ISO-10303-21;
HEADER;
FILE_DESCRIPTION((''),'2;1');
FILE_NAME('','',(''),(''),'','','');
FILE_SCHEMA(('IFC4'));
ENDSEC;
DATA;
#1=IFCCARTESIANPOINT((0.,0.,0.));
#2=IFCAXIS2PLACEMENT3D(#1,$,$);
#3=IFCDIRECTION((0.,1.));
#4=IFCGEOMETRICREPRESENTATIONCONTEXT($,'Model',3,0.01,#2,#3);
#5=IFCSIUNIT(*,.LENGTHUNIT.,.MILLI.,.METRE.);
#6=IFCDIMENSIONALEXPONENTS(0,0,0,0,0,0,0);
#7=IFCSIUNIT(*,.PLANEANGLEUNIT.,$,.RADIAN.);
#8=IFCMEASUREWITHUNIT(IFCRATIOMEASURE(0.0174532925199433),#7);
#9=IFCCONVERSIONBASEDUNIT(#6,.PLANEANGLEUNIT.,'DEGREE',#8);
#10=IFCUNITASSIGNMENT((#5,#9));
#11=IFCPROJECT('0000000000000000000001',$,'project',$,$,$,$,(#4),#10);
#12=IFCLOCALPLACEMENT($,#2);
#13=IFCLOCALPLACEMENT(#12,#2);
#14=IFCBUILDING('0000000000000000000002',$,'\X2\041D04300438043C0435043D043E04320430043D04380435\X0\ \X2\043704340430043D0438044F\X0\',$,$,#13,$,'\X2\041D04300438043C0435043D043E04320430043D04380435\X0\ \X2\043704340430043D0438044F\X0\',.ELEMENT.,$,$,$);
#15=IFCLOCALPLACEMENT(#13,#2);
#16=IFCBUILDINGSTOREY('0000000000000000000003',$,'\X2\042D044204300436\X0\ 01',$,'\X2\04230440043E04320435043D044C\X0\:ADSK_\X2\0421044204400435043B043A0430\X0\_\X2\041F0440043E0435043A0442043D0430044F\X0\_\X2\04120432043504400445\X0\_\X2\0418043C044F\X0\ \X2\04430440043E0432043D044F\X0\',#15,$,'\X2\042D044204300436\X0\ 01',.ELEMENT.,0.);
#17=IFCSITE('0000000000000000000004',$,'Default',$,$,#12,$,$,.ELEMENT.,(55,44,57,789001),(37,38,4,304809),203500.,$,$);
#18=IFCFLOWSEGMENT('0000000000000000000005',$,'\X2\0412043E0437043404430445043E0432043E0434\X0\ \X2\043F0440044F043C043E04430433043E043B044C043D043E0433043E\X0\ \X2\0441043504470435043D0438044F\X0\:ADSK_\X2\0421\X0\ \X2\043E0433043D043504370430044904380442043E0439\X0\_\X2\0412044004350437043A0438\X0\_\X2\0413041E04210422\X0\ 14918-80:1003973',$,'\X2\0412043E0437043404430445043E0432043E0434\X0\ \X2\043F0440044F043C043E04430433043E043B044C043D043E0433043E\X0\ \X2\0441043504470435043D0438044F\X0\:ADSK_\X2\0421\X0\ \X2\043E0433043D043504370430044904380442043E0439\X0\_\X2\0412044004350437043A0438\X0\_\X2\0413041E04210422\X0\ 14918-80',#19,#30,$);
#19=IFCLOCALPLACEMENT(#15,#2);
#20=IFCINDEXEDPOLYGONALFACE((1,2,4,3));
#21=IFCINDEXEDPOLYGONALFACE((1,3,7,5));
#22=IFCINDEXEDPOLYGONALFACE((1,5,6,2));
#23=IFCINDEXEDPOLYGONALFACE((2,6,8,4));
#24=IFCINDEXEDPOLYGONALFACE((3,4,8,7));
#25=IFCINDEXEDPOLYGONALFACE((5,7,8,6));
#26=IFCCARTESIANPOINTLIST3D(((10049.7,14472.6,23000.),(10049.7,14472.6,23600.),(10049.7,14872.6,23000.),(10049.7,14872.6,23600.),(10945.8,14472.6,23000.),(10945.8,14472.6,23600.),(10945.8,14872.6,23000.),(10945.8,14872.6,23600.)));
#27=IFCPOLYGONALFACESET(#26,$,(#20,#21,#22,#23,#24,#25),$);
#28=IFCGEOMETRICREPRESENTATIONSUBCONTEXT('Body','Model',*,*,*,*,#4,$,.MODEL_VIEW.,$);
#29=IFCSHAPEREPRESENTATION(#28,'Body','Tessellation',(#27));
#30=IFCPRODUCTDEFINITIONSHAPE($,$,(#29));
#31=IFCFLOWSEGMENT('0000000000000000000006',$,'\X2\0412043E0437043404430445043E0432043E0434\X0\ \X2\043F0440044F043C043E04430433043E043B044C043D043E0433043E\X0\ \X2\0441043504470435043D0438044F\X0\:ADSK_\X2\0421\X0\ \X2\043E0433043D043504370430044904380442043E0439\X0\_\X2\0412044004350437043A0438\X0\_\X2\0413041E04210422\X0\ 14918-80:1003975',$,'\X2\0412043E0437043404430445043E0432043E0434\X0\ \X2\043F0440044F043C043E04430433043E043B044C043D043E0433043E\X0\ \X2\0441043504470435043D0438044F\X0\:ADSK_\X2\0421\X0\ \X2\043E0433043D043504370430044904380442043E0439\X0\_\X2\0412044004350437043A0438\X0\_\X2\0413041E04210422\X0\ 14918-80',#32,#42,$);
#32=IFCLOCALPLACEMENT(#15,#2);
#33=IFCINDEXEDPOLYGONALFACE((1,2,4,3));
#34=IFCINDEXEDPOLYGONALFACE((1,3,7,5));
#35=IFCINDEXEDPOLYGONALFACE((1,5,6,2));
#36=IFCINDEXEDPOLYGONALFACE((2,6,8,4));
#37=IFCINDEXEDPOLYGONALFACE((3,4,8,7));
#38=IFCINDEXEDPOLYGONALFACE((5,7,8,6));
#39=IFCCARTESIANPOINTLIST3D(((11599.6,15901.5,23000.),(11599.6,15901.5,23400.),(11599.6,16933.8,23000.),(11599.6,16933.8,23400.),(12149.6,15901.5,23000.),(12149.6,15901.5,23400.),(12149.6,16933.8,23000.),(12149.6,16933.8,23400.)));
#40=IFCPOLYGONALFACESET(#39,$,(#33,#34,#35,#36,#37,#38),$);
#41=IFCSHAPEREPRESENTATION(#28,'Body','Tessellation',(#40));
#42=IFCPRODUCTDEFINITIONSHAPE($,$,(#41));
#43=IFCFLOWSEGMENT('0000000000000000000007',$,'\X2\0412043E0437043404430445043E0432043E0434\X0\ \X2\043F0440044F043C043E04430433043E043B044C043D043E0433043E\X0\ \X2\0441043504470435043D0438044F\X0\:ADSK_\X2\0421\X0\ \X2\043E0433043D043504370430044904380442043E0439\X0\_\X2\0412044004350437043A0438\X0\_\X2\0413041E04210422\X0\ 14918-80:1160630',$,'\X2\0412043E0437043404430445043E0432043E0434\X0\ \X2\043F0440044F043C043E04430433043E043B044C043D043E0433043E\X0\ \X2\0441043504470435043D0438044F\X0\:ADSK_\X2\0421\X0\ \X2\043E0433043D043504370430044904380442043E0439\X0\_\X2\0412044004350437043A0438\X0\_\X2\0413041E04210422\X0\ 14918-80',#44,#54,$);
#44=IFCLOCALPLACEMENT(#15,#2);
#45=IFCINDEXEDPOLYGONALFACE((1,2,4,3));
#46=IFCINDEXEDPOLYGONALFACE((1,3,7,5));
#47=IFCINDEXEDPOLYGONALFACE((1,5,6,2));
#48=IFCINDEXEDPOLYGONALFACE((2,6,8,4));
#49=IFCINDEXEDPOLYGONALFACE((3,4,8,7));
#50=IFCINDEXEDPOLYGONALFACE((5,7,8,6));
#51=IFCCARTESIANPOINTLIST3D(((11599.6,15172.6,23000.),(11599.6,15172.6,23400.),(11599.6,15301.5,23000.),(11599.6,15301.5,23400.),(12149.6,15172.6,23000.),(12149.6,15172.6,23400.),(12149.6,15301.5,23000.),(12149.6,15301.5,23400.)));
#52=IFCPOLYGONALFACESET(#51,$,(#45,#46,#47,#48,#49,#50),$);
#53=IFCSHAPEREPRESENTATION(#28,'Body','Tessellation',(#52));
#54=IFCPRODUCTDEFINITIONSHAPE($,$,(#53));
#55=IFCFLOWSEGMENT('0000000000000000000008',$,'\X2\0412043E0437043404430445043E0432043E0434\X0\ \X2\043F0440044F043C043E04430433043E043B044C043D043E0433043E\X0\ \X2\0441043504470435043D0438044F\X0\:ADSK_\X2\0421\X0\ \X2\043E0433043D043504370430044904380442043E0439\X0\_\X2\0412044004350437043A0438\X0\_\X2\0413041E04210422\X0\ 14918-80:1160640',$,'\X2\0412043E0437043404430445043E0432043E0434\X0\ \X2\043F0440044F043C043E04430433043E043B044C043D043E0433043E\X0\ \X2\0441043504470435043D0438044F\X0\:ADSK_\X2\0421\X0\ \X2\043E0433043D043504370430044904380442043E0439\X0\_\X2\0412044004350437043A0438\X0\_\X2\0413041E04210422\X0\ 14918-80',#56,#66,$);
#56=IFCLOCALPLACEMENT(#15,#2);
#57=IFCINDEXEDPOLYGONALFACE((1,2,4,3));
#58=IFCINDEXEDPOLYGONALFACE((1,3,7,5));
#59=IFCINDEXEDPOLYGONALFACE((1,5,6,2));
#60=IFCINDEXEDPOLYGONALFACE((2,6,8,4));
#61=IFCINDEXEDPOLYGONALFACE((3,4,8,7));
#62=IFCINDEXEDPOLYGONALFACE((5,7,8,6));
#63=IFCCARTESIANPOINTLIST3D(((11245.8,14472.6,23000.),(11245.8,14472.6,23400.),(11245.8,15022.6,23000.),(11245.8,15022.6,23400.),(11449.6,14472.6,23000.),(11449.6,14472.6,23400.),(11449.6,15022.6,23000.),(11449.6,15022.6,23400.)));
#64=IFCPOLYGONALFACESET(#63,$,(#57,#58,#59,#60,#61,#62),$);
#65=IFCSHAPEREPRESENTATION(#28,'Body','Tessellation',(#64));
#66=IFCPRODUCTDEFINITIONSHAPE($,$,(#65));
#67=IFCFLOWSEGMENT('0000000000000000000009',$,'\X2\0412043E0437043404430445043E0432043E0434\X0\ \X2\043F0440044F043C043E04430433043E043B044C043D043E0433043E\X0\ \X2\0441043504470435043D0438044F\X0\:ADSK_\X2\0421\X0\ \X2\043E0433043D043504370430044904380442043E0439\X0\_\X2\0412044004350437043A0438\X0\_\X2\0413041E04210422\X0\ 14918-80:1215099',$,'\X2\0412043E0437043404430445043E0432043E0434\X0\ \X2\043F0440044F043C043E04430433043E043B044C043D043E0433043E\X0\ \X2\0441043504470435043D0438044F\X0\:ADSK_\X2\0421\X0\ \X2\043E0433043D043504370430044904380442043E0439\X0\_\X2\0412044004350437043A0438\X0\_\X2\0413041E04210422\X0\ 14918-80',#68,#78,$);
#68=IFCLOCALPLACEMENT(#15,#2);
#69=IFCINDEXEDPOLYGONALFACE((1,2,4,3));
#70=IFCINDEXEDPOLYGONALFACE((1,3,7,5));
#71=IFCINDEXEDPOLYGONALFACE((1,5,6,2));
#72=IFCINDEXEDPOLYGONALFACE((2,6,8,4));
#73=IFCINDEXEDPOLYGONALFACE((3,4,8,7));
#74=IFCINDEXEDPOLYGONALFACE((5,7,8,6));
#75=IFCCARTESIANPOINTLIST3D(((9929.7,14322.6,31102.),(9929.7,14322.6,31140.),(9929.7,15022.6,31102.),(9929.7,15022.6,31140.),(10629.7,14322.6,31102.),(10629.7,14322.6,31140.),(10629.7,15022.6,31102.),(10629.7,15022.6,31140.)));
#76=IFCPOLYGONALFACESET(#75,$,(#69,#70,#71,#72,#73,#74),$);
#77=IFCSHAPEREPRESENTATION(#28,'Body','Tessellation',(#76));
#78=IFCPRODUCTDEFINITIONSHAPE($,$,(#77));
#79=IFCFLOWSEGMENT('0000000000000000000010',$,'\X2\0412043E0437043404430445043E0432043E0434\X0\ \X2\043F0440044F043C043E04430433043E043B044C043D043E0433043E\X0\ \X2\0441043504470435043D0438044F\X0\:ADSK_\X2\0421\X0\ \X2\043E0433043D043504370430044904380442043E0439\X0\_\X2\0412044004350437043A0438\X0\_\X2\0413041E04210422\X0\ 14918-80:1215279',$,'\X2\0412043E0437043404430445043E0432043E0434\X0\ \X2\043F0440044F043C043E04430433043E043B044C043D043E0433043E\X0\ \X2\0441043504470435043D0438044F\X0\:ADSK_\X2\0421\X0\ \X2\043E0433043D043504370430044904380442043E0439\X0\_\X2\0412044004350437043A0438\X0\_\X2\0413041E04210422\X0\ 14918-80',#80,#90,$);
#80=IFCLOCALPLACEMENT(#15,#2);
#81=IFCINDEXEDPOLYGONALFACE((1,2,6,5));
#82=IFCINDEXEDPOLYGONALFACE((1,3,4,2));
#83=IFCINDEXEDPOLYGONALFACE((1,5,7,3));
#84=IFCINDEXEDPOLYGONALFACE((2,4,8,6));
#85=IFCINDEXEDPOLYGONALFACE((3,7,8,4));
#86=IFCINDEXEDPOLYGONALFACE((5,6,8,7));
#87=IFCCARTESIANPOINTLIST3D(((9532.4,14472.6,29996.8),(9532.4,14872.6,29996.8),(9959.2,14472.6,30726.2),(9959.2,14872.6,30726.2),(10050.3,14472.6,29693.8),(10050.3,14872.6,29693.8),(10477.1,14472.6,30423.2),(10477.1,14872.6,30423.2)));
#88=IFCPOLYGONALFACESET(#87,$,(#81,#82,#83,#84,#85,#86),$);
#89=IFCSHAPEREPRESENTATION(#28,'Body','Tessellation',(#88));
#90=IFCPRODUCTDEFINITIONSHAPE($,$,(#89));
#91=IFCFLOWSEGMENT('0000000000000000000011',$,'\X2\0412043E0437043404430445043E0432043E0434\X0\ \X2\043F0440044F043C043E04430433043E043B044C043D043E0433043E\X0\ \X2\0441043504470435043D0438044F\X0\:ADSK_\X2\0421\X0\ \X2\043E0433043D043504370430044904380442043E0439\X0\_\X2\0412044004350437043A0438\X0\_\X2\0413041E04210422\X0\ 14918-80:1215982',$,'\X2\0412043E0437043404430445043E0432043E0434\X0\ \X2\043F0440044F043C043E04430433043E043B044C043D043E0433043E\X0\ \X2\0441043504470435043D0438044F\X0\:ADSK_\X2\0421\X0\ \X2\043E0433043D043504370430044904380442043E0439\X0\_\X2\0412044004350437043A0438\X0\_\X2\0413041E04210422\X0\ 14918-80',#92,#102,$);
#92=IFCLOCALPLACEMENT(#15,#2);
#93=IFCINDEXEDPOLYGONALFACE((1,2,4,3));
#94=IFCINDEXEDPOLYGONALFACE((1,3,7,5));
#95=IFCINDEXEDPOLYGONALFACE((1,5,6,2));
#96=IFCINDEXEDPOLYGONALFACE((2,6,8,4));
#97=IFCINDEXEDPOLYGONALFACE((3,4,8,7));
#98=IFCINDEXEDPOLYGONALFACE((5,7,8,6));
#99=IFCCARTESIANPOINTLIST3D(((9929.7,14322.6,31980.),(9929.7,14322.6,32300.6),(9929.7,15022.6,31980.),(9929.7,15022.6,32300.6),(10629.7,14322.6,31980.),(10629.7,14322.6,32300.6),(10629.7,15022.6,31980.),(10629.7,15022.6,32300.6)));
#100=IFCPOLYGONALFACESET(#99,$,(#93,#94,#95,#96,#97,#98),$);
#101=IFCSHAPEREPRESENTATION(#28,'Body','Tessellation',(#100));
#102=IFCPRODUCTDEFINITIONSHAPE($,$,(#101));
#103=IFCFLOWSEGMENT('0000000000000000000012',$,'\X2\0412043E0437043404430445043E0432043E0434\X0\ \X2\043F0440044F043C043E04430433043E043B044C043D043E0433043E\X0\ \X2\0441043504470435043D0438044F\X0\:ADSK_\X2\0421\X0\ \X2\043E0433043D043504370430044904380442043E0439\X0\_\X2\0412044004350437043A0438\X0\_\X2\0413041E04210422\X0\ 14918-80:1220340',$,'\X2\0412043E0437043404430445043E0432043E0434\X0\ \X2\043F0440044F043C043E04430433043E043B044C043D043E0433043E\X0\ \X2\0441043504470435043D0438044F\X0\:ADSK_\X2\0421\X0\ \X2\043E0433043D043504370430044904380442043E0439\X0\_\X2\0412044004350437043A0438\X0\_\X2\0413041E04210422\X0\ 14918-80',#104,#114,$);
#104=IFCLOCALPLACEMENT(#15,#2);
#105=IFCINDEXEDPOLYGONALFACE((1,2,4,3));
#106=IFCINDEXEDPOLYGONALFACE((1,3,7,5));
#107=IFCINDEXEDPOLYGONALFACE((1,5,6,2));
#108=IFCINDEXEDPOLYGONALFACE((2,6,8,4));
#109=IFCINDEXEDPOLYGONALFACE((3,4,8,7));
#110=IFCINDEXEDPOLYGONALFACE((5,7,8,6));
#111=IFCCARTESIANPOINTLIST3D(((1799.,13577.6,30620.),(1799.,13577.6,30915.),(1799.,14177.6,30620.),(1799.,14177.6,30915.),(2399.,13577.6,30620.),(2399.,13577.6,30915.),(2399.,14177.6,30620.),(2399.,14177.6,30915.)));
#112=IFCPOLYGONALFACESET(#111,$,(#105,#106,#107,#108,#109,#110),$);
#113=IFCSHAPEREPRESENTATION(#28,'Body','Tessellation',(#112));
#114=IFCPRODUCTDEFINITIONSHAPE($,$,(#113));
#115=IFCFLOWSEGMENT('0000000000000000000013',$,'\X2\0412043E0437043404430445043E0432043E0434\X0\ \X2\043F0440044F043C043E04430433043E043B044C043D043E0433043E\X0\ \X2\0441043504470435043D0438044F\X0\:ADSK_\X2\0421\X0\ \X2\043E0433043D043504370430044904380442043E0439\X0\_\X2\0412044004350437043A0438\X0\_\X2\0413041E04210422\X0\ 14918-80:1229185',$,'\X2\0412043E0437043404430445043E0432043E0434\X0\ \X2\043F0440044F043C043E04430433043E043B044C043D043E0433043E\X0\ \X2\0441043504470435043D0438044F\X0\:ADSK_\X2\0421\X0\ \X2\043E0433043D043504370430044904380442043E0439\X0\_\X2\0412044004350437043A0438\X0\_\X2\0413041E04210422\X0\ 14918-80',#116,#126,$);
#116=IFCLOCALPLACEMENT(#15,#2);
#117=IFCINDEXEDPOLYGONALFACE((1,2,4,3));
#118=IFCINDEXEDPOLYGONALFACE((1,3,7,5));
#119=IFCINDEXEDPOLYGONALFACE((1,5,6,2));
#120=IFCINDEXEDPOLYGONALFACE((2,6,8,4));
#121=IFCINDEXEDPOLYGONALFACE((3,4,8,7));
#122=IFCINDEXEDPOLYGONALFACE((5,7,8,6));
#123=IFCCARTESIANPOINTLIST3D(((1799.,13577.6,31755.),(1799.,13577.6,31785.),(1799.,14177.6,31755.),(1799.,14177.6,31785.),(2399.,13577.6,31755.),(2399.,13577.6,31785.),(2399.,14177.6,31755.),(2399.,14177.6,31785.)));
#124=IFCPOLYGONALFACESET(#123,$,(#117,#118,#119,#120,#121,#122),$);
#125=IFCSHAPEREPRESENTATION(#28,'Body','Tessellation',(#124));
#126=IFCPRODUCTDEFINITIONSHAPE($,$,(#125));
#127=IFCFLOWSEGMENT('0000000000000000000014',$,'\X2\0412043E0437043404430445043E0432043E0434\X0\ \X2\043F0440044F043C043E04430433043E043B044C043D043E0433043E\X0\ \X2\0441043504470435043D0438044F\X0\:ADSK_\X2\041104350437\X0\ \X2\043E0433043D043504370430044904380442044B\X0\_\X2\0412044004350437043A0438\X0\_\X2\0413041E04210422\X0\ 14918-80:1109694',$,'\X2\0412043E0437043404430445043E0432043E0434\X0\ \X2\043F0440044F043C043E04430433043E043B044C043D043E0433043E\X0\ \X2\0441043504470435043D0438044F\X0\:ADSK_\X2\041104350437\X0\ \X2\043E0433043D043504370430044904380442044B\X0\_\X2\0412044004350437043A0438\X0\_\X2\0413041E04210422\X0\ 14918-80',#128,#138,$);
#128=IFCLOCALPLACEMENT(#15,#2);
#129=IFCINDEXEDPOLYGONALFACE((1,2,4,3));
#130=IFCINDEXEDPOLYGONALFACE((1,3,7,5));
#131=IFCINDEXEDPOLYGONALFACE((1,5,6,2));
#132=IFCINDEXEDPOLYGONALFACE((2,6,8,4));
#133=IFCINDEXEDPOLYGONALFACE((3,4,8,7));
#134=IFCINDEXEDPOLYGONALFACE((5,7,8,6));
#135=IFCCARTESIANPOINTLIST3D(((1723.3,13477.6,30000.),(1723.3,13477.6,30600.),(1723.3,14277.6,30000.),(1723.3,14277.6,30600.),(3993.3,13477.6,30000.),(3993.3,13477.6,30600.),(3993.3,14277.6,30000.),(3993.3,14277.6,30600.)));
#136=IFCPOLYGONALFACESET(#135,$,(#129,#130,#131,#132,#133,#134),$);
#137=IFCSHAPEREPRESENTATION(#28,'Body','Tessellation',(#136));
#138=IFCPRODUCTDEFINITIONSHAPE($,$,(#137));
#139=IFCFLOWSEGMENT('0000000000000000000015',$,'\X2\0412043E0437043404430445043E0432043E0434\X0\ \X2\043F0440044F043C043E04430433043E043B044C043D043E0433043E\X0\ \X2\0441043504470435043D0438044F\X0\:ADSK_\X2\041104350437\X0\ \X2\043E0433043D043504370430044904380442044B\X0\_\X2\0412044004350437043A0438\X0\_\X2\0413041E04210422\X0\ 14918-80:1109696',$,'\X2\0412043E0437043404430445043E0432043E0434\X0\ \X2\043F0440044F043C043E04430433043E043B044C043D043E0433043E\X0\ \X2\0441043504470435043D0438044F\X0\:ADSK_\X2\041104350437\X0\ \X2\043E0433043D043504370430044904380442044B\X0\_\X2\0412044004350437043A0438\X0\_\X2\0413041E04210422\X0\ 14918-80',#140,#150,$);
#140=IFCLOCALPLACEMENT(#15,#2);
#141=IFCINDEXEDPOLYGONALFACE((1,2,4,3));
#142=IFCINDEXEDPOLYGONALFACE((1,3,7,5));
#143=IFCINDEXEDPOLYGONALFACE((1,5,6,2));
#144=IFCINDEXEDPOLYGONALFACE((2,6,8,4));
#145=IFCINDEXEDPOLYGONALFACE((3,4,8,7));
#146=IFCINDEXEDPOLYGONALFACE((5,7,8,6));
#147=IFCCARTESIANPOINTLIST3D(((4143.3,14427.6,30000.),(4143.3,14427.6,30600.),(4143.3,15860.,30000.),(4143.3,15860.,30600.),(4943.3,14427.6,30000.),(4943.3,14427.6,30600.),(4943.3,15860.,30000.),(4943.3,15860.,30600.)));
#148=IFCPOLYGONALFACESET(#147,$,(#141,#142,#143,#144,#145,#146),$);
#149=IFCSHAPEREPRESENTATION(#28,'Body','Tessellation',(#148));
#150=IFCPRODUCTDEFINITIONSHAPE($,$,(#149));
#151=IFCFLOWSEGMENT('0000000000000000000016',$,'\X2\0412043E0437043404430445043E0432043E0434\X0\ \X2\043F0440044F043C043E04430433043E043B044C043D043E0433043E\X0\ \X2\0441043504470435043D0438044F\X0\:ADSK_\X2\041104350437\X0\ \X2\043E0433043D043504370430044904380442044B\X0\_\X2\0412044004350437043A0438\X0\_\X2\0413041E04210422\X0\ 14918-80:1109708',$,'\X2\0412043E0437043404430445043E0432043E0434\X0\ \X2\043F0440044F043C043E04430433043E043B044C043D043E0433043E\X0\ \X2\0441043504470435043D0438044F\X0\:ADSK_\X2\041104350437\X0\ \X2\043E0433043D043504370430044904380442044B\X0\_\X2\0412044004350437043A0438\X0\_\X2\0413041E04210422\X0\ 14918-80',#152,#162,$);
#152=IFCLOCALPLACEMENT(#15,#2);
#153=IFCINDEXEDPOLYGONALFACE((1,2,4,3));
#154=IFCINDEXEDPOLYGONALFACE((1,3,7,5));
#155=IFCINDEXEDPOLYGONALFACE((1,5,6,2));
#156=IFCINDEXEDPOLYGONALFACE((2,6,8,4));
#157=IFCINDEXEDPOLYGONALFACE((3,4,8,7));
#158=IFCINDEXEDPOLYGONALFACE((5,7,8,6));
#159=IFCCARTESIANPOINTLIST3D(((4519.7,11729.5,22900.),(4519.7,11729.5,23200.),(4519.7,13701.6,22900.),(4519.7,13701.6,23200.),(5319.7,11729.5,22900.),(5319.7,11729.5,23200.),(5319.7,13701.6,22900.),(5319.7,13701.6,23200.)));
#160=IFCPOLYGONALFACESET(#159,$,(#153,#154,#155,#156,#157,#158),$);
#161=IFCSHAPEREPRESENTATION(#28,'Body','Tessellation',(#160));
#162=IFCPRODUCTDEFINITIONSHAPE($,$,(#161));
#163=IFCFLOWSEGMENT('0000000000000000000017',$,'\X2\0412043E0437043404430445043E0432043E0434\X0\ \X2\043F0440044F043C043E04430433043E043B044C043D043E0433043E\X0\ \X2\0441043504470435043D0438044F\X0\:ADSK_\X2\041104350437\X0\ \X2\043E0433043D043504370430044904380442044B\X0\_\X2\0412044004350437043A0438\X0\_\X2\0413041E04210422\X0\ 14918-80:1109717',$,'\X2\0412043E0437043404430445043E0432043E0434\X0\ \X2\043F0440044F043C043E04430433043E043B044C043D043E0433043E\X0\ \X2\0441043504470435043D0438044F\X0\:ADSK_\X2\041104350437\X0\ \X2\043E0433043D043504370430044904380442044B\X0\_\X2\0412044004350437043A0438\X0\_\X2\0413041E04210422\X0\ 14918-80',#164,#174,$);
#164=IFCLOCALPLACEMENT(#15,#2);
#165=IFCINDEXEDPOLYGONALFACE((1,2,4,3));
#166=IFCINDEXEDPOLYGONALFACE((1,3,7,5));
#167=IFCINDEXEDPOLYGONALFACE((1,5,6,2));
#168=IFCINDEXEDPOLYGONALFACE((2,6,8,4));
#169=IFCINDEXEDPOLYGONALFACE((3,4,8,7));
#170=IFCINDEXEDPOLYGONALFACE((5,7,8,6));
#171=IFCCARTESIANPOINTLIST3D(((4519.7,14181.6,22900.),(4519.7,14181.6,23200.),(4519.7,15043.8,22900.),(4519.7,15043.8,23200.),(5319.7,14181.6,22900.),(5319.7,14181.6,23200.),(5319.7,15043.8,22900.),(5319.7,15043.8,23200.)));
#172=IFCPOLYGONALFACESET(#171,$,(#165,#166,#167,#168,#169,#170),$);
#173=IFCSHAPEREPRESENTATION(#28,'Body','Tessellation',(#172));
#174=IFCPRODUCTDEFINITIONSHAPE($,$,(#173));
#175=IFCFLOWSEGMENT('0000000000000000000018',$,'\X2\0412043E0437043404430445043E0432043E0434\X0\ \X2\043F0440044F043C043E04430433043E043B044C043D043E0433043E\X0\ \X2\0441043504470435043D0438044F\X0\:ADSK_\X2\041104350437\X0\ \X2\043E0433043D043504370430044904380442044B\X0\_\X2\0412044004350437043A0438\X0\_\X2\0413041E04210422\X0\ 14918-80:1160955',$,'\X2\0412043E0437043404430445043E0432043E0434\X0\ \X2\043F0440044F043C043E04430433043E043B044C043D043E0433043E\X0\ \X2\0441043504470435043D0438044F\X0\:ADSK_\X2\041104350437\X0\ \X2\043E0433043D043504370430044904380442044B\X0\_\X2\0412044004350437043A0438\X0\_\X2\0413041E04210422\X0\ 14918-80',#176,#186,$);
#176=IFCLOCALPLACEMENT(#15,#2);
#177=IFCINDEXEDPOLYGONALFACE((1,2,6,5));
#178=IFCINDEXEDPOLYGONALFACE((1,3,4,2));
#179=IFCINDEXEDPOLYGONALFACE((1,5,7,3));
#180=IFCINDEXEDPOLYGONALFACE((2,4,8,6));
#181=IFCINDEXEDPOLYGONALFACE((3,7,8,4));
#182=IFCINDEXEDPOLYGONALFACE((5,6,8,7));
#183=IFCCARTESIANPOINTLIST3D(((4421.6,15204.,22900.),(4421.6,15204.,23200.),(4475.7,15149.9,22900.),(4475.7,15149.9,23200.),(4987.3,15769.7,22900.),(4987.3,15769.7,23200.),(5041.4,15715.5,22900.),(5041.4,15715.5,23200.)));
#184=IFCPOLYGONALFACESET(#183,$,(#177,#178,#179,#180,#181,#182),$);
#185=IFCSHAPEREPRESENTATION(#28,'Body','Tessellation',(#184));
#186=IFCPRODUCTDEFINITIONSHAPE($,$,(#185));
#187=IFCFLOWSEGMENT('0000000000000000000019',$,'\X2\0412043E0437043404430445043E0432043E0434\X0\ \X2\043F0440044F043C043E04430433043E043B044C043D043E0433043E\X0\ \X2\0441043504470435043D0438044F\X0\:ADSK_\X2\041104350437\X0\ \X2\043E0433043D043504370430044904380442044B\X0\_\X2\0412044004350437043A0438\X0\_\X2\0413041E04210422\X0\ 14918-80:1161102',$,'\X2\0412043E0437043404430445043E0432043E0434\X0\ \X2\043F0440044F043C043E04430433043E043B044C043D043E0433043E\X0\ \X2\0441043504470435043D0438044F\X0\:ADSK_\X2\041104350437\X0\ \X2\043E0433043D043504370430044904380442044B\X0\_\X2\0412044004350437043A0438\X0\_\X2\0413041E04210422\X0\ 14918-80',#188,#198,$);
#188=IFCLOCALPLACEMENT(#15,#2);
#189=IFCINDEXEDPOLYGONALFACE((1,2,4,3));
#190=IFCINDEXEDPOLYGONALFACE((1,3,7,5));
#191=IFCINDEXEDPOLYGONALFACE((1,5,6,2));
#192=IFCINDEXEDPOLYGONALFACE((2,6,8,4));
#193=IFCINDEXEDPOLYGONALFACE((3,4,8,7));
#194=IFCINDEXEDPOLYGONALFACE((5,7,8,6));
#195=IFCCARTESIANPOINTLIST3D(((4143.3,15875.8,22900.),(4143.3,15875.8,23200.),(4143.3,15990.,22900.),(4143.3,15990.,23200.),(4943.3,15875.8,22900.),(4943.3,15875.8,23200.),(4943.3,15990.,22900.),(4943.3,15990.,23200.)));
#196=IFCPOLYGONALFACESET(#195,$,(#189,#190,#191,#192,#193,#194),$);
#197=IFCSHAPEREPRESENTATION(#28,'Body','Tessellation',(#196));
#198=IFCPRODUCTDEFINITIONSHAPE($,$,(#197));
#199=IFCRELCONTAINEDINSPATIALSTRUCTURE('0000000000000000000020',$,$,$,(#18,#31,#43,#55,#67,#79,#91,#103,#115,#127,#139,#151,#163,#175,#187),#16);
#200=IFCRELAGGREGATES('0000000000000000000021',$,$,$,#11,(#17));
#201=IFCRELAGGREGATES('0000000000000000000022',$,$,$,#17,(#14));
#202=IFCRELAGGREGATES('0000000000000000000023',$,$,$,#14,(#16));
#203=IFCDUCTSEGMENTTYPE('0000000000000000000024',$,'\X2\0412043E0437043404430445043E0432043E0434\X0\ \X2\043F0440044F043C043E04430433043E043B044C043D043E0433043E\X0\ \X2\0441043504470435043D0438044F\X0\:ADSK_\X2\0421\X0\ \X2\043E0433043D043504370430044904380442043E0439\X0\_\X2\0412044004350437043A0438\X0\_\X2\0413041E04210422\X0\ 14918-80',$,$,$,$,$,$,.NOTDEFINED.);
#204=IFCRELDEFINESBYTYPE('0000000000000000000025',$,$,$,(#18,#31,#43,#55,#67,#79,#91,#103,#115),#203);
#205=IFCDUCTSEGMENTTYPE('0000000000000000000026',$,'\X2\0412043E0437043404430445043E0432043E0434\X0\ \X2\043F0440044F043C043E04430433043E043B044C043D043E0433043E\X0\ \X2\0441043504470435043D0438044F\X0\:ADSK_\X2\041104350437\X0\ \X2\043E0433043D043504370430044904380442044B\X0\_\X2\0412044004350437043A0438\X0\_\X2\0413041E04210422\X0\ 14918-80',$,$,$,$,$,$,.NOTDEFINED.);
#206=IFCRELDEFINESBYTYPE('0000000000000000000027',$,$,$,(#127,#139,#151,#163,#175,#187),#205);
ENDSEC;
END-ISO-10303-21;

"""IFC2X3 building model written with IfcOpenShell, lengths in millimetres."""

from ifc_helpers import new_model, entity, si_unit, converted_unit, direction, frame, frame_2d, origin, origin_2d_with_axis, place, context, subcontext, project, spatial, rectangle, extrude, type_object, element, save


model = new_model("IFC2X3")

# Units and contexts
model_context = context("Model", 3, precision=0.01, world=origin(), true_north=direction((0.0, 1.0)))
body_context = subcontext(model_context, "Body", "Model", "MODEL_VIEW")
ifc_project = project(units=[si_unit("LENGTHUNIT", "METRE", prefix="MILLI"), converted_unit("PLANEANGLEUNIT", "DEGREE", entity("IfcRatioMeasure", 0.0174532925199433), si_unit("PLANEANGLEUNIT", "RADIAN"), dimensions=[0, 0, 0, 0, 0, 0, 0])], contexts=[model_context])

# Site, building, storey
site_placement = place(None, origin())
site = spatial("IfcSite", under=ifc_project, at=site_placement, Name="Default", CompositionType="ELEMENT", RefLatitude=(55, 44, 57, 789001), RefLongitude=(37, 38, 4, 304809), RefElevation=203500.0)
building_placement = place(site_placement, origin())
building = spatial("IfcBuilding", under=site, at=building_placement, Name="Наименование здания", LongName="Наименование здания", CompositionType="ELEMENT")
storey_placement = place(building_placement, origin())
storey = spatial("IfcBuildingStorey", under=building, at=storey_placement, Name="Этаж 01", ObjectType="Уровень:ADSK_Стрелка_Проектная_Вверх_Имя уровня", LongName="Этаж 01", CompositionType="ELEMENT", Elevation=0.0)

# Flow segments
duct_segment_type_1 = type_object("IfcDuctSegmentType", Name="Воздуховод прямоугольного сечения:ADSK_С огнезащитой_Врезки_ГОСТ 14918-80", PredefinedType="NOTDEFINED")
flow_segment_1_placement = place(storey_placement, frame((10049.7, 14472.6, 23000.0)))
element("IfcFlowSegment", 1, at=flow_segment_1_placement, inside=storey, type_object=duct_segment_type_1, Name="Воздуховод прямоугольного сечения:ADSK_С огнезащитой_Врезки_ГОСТ 14918-80:1003973", ObjectType="Воздуховод прямоугольного сечения:ADSK_С огнезащитой_Врезки_ГОСТ 14918-80", context=body_context, shape_type="SweptSolid", body=[
    extrude(rectangle(XDim=896.0, YDim=400.0, at=origin_2d_with_axis()), frame((448.0, 200.0, 0.0)), (0.0, 0.0, 1.0), 600.0),
])
flow_segment_2_placement = place(storey_placement, frame((11599.6, 15901.5, 23000.0)))
element("IfcFlowSegment", 2, at=flow_segment_2_placement, inside=storey, type_object=duct_segment_type_1, Name="Воздуховод прямоугольного сечения:ADSK_С огнезащитой_Врезки_ГОСТ 14918-80:1003975", ObjectType="Воздуховод прямоугольного сечения:ADSK_С огнезащитой_Врезки_ГОСТ 14918-80", context=body_context, shape_type="SweptSolid", body=[
    extrude(rectangle(XDim=1032.3, YDim=550.0, at=origin_2d_with_axis()), frame((275.0, 516.1, 0.0), z_axis=(0.0, 0.0, 1.0), x_axis=(0.0, 1.0, 0.0)), (0.0, 0.0, 1.0), 400.0),
])
flow_segment_3_placement = place(storey_placement, frame((11599.6, 15172.6, 23000.0)))
element("IfcFlowSegment", 3, at=flow_segment_3_placement, inside=storey, type_object=duct_segment_type_1, Name="Воздуховод прямоугольного сечения:ADSK_С огнезащитой_Врезки_ГОСТ 14918-80:1160630", ObjectType="Воздуховод прямоугольного сечения:ADSK_С огнезащитой_Врезки_ГОСТ 14918-80", context=body_context, shape_type="SweptSolid", body=[
    extrude(rectangle(XDim=128.9, YDim=550.0, at=origin_2d_with_axis()), frame((275.0, 64.5, 0.0), z_axis=(0.0, 0.0, 1.0), x_axis=(0.0, -1.0, 0.0)), (0.0, 0.0, 1.0), 400.0),
])
flow_segment_4_placement = place(storey_placement, frame((11245.8, 14472.6, 23000.0)))
element("IfcFlowSegment", 4, at=flow_segment_4_placement, inside=storey, type_object=duct_segment_type_1, Name="Воздуховод прямоугольного сечения:ADSK_С огнезащитой_Врезки_ГОСТ 14918-80:1160640", ObjectType="Воздуховод прямоугольного сечения:ADSK_С огнезащитой_Врезки_ГОСТ 14918-80", context=body_context, shape_type="SweptSolid", body=[
    extrude(rectangle(XDim=203.9, YDim=550.0, at=origin_2d_with_axis()), frame((101.9, 275.0, 0.0)), (0.0, 0.0, 1.0), 400.0),
])
flow_segment_5_placement = place(storey_placement, frame((9929.7, 14322.6, 31102.0)))
element("IfcFlowSegment", 5, at=flow_segment_5_placement, inside=storey, type_object=duct_segment_type_1, Name="Воздуховод прямоугольного сечения:ADSK_С огнезащитой_Врезки_ГОСТ 14918-80:1215099", ObjectType="Воздуховод прямоугольного сечения:ADSK_С огнезащитой_Врезки_ГОСТ 14918-80", context=body_context, shape_type="SweptSolid", body=[
    extrude(rectangle(XDim=700.0, YDim=700.0, at=origin_2d_with_axis()), frame((350.0, 350.0, 0.0), z_axis=(0.0, 0.0, 1.0), x_axis=(0.0, 1.0, 0.0)), (0.0, 0.0, 1.0), 38.0),
])
flow_segment_6_placement = place(storey_placement, frame((9532.4, 14472.6, 29693.8)))
element("IfcFlowSegment", 6, at=flow_segment_6_placement, inside=storey, type_object=duct_segment_type_1, Name="Воздуховод прямоугольного сечения:ADSK_С огнезащитой_Врезки_ГОСТ 14918-80:1215279", ObjectType="Воздуховод прямоугольного сечения:ADSK_С огнезащитой_Врезки_ГОСТ 14918-80", context=body_context, shape_type="SweptSolid", body=[
    extrude(rectangle(XDim=600.0, YDim=400.0, at=frame_2d((0.0, 0.0), x_axis=(0.0, 1.0))), frame((258.9, 200.0, 151.5), z_axis=(0.505012, 0.0, 0.863112), x_axis=(0.0, 1.0, 0.0)), (0.0, 0.0, 1.0), 845.1),
])
flow_segment_7_placement = place(storey_placement, frame((9929.7, 14322.6, 31980.0)))
element("IfcFlowSegment", 7, at=flow_segment_7_placement, inside=storey, type_object=duct_segment_type_1, Name="Воздуховод прямоугольного сечения:ADSK_С огнезащитой_Врезки_ГОСТ 14918-80:1215982", ObjectType="Воздуховод прямоугольного сечения:ADSK_С огнезащитой_Врезки_ГОСТ 14918-80", context=body_context, shape_type="SweptSolid", body=[
    extrude(rectangle(XDim=700.0, YDim=700.0, at=origin_2d_with_axis()), frame((350.0, 350.0, 0.0), z_axis=(0.0, 0.0, 1.0), x_axis=(0.0, 1.0, 0.0)), (0.0, 0.0, 1.0), 320.6),
])
flow_segment_8_placement = place(storey_placement, frame((1799.0, 13577.6, 30620.0)))
element("IfcFlowSegment", 8, at=flow_segment_8_placement, inside=storey, type_object=duct_segment_type_1, Name="Воздуховод прямоугольного сечения:ADSK_С огнезащитой_Врезки_ГОСТ 14918-80:1220340", ObjectType="Воздуховод прямоугольного сечения:ADSK_С огнезащитой_Врезки_ГОСТ 14918-80", context=body_context, shape_type="SweptSolid", body=[
    extrude(rectangle(XDim=600.0, YDim=600.0, at=origin_2d_with_axis()), frame((300.0, 300.0, 0.0), z_axis=(0.0, 0.0, 1.0), x_axis=(0.0, -1.0, 0.0)), (0.0, 0.0, 1.0), 295.0),
])
flow_segment_9_placement = place(storey_placement, frame((1799.0, 13577.6, 31755.0)))
element("IfcFlowSegment", 9, at=flow_segment_9_placement, inside=storey, type_object=duct_segment_type_1, Name="Воздуховод прямоугольного сечения:ADSK_С огнезащитой_Врезки_ГОСТ 14918-80:1229185", ObjectType="Воздуховод прямоугольного сечения:ADSK_С огнезащитой_Врезки_ГОСТ 14918-80", context=body_context, shape_type="SweptSolid", body=[
    extrude(rectangle(XDim=600.0, YDim=600.0, at=origin_2d_with_axis()), frame((300.0, 300.0, 0.0), z_axis=(0.0, 0.0, 1.0), x_axis=(0.0, -1.0, 0.0)), (0.0, 0.0, 1.0), 30.0),
])
duct_segment_type_2 = type_object("IfcDuctSegmentType", Name="Воздуховод прямоугольного сечения:ADSK_Без огнезащиты_Врезки_ГОСТ 14918-80", PredefinedType="NOTDEFINED")
flow_segment_10_placement = place(storey_placement, frame((1723.3, 13477.6, 30000.0)))
element("IfcFlowSegment", 10, at=flow_segment_10_placement, inside=storey, type_object=duct_segment_type_2, Name="Воздуховод прямоугольного сечения:ADSK_Без огнезащиты_Врезки_ГОСТ 14918-80:1109694", ObjectType="Воздуховод прямоугольного сечения:ADSK_Без огнезащиты_Врезки_ГОСТ 14918-80", context=body_context, shape_type="SweptSolid", body=[
    extrude(rectangle(XDim=2270.0, YDim=800.0, at=origin_2d_with_axis()), frame((1135.0, 400.0, 0.0), z_axis=(0.0, 0.0, 1.0), x_axis=(-1.0, 0.0, 0.0)), (0.0, 0.0, 1.0), 600.0),
])
flow_segment_11_placement = place(storey_placement, frame((4143.3, 14427.6, 30000.0)))
element("IfcFlowSegment", 11, at=flow_segment_11_placement, inside=storey, type_object=duct_segment_type_2, Name="Воздуховод прямоугольного сечения:ADSK_Без огнезащиты_Врезки_ГОСТ 14918-80:1109696", ObjectType="Воздуховод прямоугольного сечения:ADSK_Без огнезащиты_Врезки_ГОСТ 14918-80", context=body_context, shape_type="SweptSolid", body=[
    extrude(rectangle(XDim=1432.4, YDim=800.0, at=origin_2d_with_axis()), frame((400.0, 716.2, 0.0), z_axis=(0.0, 0.0, 1.0), x_axis=(0.0, -1.0, 0.0)), (0.0, 0.0, 1.0), 600.0),
])
flow_segment_12_placement = place(storey_placement, frame((4519.7, 11729.5, 22900.0)))
element("IfcFlowSegment", 12, at=flow_segment_12_placement, inside=storey, type_object=duct_segment_type_2, Name="Воздуховод прямоугольного сечения:ADSK_Без огнезащиты_Врезки_ГОСТ 14918-80:1109708", ObjectType="Воздуховод прямоугольного сечения:ADSK_Без огнезащиты_Врезки_ГОСТ 14918-80", context=body_context, shape_type="SweptSolid", body=[
    extrude(rectangle(XDim=1972.1, YDim=800.0, at=origin_2d_with_axis()), frame((400.0, 986.0, 0.0), z_axis=(0.0, 0.0, 1.0), x_axis=(0.0, -1.0, 0.0)), (0.0, 0.0, 1.0), 300.0),
])
flow_segment_13_placement = place(storey_placement, frame((4519.7, 14181.6, 22900.0)))
element("IfcFlowSegment", 13, at=flow_segment_13_placement, inside=storey, type_object=duct_segment_type_2, Name="Воздуховод прямоугольного сечения:ADSK_Без огнезащиты_Врезки_ГОСТ 14918-80:1109717", ObjectType="Воздуховод прямоугольного сечения:ADSK_Без огнезащиты_Врезки_ГОСТ 14918-80", context=body_context, shape_type="SweptSolid", body=[
    extrude(rectangle(XDim=862.2, YDim=800.0, at=origin_2d_with_axis()), frame((400.0, 431.1, 0.0), z_axis=(0.0, 0.0, 1.0), x_axis=(0.0, 1.0, 0.0)), (0.0, 0.0, 1.0), 300.0),
])
flow_segment_14_placement = place(storey_placement, frame((4421.6, 15149.9, 22900.0)))
element("IfcFlowSegment", 14, at=flow_segment_14_placement, inside=storey, type_object=duct_segment_type_2, Name="Воздуховод прямоугольного сечения:ADSK_Без огнезащиты_Врезки_ГОСТ 14918-80:1160955", ObjectType="Воздуховод прямоугольного сечения:ADSK_Без огнезащиты_Врезки_ГОСТ 14918-80", context=body_context, shape_type="SweptSolid", body=[
    extrude(rectangle(XDim=76.6, YDim=800.0, at=origin_2d_with_axis()), frame((309.9, 309.9, 0.0), z_axis=(0.0, 0.0, 1.0), x_axis=(-0.707107, 0.707107, 0.0)), (0.0, 0.0, 1.0), 300.0),
])
flow_segment_15_placement = place(storey_placement, frame((4143.3, 15875.8, 22900.0)))
element("IfcFlowSegment", 15, at=flow_segment_15_placement, inside=storey, type_object=duct_segment_type_2, Name="Воздуховод прямоугольного сечения:ADSK_Без огнезащиты_Врезки_ГОСТ 14918-80:1161102", ObjectType="Воздуховод прямоугольного сечения:ADSK_Без огнезащиты_Врезки_ГОСТ 14918-80", context=body_context, shape_type="SweptSolid", body=[
    extrude(rectangle(XDim=114.2, YDim=800.0, at=origin_2d_with_axis()), frame((400.0, 57.1, 0.0), z_axis=(0.0, 0.0, 1.0), x_axis=(0.0, 1.0, 0.0)), (0.0, 0.0, 1.0), 300.0),
])

save(model, "model.ifc")
